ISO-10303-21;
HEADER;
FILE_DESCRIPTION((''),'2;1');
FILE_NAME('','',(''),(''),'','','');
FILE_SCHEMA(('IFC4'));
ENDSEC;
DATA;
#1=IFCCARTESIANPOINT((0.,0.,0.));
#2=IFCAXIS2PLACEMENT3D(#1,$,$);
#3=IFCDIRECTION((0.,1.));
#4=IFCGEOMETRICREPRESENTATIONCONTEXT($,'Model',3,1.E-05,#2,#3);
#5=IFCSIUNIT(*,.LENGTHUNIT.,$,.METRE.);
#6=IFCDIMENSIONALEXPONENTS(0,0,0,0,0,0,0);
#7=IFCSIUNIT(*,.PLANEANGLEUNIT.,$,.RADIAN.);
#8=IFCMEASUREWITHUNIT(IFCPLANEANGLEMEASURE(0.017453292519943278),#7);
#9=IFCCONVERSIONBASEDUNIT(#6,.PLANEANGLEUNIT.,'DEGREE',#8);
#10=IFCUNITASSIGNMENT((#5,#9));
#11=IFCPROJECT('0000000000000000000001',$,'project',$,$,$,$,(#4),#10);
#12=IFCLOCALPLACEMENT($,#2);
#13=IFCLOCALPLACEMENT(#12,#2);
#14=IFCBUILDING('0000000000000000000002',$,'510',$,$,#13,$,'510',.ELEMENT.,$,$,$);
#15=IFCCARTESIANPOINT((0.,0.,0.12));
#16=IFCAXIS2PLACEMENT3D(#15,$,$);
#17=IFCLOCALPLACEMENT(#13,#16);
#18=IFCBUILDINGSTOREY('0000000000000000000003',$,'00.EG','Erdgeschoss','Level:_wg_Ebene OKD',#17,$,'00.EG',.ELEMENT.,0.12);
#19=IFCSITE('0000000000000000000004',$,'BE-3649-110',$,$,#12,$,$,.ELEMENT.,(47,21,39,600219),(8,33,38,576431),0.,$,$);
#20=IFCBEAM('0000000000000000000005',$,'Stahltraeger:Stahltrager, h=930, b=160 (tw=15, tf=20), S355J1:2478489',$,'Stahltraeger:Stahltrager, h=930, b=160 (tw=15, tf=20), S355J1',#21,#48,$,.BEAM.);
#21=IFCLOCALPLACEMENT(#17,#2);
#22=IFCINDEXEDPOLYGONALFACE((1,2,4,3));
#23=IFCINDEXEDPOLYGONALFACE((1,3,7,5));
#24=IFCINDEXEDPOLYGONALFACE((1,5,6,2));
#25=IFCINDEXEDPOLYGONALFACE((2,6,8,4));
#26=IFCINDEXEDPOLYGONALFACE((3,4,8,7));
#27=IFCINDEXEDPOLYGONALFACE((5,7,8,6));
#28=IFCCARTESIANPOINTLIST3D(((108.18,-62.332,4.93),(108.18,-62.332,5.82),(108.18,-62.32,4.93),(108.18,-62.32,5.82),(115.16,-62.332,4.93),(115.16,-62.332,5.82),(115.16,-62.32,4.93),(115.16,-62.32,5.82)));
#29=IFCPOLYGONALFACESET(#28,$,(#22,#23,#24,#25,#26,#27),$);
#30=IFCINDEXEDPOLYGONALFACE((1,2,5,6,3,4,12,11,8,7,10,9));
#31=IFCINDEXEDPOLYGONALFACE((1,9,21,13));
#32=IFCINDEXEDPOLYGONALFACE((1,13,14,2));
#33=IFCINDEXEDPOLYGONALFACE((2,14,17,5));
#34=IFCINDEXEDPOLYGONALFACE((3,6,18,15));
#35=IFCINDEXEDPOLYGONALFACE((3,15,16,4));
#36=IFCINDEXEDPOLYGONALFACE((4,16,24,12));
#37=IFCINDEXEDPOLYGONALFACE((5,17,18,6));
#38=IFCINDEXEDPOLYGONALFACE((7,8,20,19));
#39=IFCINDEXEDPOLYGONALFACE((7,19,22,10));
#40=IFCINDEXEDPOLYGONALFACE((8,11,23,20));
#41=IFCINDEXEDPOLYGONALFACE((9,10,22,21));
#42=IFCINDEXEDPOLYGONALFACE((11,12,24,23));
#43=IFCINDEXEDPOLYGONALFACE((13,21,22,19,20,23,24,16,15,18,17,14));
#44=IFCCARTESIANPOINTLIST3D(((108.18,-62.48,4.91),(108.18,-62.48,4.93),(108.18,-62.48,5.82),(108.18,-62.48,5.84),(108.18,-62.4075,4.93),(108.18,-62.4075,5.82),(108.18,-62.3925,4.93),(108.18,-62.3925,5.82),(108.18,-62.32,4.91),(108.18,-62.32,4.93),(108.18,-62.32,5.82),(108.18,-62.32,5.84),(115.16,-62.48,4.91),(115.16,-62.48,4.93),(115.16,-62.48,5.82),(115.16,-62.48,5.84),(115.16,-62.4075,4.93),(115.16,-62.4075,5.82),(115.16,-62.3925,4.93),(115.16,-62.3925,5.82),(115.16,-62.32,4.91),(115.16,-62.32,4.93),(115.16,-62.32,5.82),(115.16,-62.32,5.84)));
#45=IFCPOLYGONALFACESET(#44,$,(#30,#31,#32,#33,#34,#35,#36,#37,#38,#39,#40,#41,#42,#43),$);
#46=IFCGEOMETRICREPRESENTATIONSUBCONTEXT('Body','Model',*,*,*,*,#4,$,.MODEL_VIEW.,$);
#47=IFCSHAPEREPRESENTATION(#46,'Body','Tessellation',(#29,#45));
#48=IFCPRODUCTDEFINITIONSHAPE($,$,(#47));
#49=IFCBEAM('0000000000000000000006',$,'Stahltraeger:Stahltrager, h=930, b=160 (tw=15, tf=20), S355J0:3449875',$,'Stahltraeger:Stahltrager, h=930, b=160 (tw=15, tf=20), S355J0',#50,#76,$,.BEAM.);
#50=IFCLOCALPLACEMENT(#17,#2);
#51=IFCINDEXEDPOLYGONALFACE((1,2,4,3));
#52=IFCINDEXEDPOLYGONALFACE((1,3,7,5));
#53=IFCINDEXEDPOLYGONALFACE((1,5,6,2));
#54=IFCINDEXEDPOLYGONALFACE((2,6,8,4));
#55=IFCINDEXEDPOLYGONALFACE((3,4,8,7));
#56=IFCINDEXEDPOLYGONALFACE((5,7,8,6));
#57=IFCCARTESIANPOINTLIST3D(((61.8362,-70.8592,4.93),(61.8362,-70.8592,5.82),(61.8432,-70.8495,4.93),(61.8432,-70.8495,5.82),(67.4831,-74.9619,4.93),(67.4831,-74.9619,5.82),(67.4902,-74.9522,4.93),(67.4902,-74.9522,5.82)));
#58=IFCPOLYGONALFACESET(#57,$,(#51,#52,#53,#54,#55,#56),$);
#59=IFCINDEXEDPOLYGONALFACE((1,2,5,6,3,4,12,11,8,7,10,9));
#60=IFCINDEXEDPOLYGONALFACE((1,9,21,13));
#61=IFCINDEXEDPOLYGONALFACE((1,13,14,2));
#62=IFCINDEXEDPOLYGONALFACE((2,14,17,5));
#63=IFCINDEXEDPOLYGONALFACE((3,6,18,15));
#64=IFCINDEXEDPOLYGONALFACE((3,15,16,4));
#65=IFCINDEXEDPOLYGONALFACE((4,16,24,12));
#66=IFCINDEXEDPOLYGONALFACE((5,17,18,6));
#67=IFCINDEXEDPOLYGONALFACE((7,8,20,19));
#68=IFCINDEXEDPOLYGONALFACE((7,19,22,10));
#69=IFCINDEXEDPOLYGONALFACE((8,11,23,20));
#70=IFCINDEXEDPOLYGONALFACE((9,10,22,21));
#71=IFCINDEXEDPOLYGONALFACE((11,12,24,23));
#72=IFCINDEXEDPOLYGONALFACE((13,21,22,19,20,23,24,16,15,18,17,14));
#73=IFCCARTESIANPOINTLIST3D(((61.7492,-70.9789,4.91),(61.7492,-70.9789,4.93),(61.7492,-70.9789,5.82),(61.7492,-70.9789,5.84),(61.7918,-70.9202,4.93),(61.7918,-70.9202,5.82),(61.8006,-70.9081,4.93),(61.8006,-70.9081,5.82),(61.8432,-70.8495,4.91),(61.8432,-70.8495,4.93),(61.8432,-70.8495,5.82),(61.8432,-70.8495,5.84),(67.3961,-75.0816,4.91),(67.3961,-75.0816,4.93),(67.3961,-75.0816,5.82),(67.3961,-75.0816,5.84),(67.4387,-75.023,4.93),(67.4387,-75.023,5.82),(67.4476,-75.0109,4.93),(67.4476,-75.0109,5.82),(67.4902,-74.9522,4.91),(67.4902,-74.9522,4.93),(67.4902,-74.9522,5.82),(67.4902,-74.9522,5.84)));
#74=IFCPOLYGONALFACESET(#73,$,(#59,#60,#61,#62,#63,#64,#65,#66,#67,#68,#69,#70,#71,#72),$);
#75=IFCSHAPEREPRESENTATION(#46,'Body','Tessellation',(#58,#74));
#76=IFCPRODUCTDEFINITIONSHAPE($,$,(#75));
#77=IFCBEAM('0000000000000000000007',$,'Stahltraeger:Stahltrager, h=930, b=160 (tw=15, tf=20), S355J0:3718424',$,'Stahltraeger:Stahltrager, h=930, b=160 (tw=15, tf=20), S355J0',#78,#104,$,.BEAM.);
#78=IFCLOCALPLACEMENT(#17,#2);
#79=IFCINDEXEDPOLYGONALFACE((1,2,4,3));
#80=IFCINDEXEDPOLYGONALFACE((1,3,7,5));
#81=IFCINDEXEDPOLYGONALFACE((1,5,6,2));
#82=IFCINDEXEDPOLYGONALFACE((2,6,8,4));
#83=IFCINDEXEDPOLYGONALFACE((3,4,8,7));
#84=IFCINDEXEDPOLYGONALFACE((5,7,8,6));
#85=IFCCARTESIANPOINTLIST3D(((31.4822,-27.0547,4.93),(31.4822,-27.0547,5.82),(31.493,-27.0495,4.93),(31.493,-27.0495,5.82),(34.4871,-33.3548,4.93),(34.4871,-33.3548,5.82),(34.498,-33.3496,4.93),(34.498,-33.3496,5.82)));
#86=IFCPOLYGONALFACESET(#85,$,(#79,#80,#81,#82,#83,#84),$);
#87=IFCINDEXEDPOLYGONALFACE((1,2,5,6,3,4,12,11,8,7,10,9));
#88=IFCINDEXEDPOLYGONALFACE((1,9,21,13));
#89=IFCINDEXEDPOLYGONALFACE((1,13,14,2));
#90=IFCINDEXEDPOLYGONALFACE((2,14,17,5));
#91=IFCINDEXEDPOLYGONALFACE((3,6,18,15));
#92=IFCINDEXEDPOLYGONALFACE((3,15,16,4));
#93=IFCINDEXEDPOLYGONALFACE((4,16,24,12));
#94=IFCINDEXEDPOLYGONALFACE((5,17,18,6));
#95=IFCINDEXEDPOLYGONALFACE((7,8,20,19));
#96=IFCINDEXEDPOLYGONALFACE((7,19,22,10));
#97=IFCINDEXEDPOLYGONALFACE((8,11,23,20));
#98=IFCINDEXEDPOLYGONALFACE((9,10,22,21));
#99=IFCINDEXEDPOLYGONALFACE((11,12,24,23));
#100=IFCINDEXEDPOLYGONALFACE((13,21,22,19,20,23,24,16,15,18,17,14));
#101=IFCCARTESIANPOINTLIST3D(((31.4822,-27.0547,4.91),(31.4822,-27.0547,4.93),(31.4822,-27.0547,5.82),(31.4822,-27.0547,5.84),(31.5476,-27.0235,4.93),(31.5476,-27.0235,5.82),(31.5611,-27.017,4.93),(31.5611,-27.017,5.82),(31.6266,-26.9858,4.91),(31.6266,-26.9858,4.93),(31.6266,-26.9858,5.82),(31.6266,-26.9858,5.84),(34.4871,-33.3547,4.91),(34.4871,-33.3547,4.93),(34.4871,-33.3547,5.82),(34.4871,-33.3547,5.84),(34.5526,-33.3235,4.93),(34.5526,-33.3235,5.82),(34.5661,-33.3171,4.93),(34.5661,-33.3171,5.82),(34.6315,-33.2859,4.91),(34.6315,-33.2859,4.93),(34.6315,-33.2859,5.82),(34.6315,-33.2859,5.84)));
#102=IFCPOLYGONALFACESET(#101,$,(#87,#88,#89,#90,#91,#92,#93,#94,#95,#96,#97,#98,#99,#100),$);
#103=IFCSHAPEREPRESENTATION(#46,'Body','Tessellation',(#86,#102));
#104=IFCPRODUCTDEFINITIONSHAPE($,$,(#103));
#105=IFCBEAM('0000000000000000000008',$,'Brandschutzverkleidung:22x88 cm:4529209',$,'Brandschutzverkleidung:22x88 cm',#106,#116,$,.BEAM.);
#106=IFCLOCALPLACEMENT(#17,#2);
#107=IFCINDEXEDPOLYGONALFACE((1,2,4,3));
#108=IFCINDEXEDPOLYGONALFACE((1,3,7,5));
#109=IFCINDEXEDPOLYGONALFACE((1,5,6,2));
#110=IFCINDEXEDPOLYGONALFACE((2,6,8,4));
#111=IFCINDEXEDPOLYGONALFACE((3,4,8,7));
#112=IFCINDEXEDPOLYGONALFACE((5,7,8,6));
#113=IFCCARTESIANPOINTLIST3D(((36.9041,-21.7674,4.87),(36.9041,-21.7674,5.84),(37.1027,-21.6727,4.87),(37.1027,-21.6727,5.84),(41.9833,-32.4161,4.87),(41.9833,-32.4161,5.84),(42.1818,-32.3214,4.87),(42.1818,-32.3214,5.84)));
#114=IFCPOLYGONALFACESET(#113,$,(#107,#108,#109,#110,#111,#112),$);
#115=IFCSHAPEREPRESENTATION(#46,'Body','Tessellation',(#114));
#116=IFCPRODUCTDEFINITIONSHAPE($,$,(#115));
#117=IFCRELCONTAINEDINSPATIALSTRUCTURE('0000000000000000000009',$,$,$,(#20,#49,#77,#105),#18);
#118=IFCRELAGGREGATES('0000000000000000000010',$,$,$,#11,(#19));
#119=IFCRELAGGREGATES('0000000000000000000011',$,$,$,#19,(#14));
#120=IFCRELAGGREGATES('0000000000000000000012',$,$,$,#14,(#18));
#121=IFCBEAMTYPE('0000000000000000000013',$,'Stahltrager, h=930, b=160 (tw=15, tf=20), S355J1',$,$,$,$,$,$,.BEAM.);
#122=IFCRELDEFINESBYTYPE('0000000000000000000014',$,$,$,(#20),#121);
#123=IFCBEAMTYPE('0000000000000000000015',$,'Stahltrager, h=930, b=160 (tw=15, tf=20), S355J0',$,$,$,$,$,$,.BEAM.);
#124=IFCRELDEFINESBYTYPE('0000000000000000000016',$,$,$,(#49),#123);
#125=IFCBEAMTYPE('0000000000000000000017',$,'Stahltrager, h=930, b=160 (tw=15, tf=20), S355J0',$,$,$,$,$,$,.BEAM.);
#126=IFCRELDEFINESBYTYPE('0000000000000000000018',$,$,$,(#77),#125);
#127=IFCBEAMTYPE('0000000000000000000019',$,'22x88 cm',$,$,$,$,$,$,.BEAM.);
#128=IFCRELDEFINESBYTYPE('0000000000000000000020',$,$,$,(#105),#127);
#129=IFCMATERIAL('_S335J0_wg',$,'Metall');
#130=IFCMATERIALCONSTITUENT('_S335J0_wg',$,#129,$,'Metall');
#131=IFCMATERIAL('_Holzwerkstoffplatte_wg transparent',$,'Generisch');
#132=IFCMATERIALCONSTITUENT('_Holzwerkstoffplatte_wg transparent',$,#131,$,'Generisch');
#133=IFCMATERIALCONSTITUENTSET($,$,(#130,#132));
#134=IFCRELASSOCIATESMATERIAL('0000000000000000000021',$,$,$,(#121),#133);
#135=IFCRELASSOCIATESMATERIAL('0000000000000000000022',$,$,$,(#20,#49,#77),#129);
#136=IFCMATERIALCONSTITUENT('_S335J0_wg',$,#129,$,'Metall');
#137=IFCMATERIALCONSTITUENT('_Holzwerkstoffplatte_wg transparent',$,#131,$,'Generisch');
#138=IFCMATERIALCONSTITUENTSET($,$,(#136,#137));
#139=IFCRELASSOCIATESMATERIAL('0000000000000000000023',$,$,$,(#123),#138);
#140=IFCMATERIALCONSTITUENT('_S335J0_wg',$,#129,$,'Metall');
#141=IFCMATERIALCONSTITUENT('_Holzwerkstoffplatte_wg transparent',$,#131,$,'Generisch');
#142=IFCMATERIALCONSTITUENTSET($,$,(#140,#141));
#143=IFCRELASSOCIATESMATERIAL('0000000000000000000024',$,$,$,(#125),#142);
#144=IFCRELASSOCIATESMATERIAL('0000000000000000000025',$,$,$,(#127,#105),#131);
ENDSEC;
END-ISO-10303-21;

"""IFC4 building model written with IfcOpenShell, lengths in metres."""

from ifc_helpers import new_model, entity, si_unit, converted_unit, direction, frame, origin, place, context, subcontext, project, spatial, indexed_curve, outline, extrude, source, transform, mapped, material, constituent, constituent_set, type_object, type_shapes, element, save


model = new_model("IFC4")

# Units and contexts
model_context = context("Model", 3, precision=1e-05, world=origin(), true_north=direction((0.0, 1.0)))
body_context = subcontext(model_context, "Body", "Model", "MODEL_VIEW")
ifc_project = project(units=[si_unit("LENGTHUNIT", "METRE"), converted_unit("PLANEANGLEUNIT", "DEGREE", entity("IfcPlaneAngleMeasure", 0.017453292519943278), si_unit("PLANEANGLEUNIT", "RADIAN"), dimensions=[0, 0, 0, 0, 0, 0, 0])], contexts=[model_context])

# Site, building, storey
site_placement = place(None, origin())
site = spatial("IfcSite", under=ifc_project, at=site_placement, Name="BE-3649-110", CompositionType="ELEMENT", RefLatitude=(47, 21, 39, 600219), RefLongitude=(8, 33, 38, 576431), RefElevation=0.0)
building_placement = place(site_placement, origin())
building = spatial("IfcBuilding", under=site, at=building_placement, Name="510", LongName="510", CompositionType="ELEMENT")
storey_placement = place(building_placement, frame((0.0, 0.0, 0.12)))
storey = spatial("IfcBuildingStorey", under=building, at=storey_placement, Name="00.EG", Description="Erdgeschoss", ObjectType="Level:_wg_Ebene OKD", LongName="00.EG", CompositionType="ELEMENT", Elevation=0.12)

# Beams
ifc_material_1 = material(Name="_S335J0_wg", Category="Metall")
ifc_material_2 = material(Name="_Holzwerkstoffplatte_wg transparent", Category="Generisch")
ifc_constituent_1 = constituent(ifc_material_1, Name="_S335J0_wg", Category="Metall")
ifc_constituent_2 = constituent(ifc_material_2, Name="_Holzwerkstoffplatte_wg transparent", Category="Generisch")
ifc_constituent_set_1 = constituent_set(constituents=[ifc_constituent_1, ifc_constituent_2])
beam_type_1 = type_object("IfcBeamType", Name="Stahltrager, h=930, b=160 (tw=15, tf=20), S355J1", PredefinedType="BEAM", material=ifc_constituent_set_1)
shared_shape_1 = source(origin(), body_context, "Body", "SweptSolid", [
    extrude(outline(indexed_curve([(-0.445, -0.006), (0.445, -0.006), (0.445, 0.006), (-0.445, 0.006), (-0.445, -0.006)], self_intersect=False)), frame((108.18, -62.326, 5.495), z_axis=(1.0, 0.0, 0.0), x_axis=(0.0, 0.0, -1.0)), (0.0, 0.0, 1.0), 6.98),
    extrude(outline(indexed_curve([(-0.465, -0.08), (-0.445, -0.08), (-0.445, -0.0075), (0.445, -0.0075), (0.445, -0.08), (0.465, -0.08), (0.465, 0.08), (0.445, 0.08), (0.445, 0.0075), (-0.445, 0.0075), (-0.445, 0.08), (-0.465, 0.08), (-0.465, -0.08)], self_intersect=False)), frame((108.18, -62.4, 5.495), z_axis=(1.0, 0.0, 0.0), x_axis=(0.0, 0.0, -1.0)), (0.0, 0.0, 1.0), 6.98),
])
type_shapes(beam_type_1, [shared_shape_1])
beam_1_placement = place(storey_placement, frame((0.0, 0.0, -0.12)))
element("IfcBeam", 1, at=beam_1_placement, inside=storey, type_object=beam_type_1, material=ifc_material_1, Name="Stahltraeger:Stahltrager, h=930, b=160 (tw=15, tf=20), S355J1:2478489", ObjectType="Stahltraeger:Stahltrager, h=930, b=160 (tw=15, tf=20), S355J1", PredefinedType="BEAM", context=body_context, shape_type="MappedRepresentation", body=[
    mapped(shared_shape_1, transform((0.0, 0.0, 0.0), scale=1.0)),
])
ifc_constituent_3 = constituent(ifc_material_1, Name="_S335J0_wg", Category="Metall")
ifc_constituent_4 = constituent(ifc_material_2, Name="_Holzwerkstoffplatte_wg transparent", Category="Generisch")
ifc_constituent_set_2 = constituent_set(constituents=[ifc_constituent_3, ifc_constituent_4])
beam_type_2 = type_object("IfcBeamType", Name="Stahltrager, h=930, b=160 (tw=15, tf=20), S355J0", PredefinedType="BEAM", material=ifc_constituent_set_2)
shared_shape_2 = source(origin(), body_context, "Body", "SweptSolid", [
    extrude(outline(indexed_curve([(-0.445, -0.006), (0.445, -0.006), (0.445, 0.006), (-0.445, 0.006), (-0.445, -0.006)], self_intersect=False)), frame((61.8397, -70.8543, 5.495), z_axis=(0.809017, -0.587785, 0.0), x_axis=(0.0, 0.0, -1.0)), (0.0, 0.0, 1.0), 6.98),
    extrude(outline(indexed_curve([(-0.465, -0.08), (-0.445, -0.08), (-0.445, -0.0075), (0.445, -0.0075), (0.445, -0.08), (0.465, -0.08), (0.465, 0.08), (0.445, 0.08), (0.445, 0.0075), (-0.445, 0.0075), (-0.445, 0.08), (-0.465, 0.08), (-0.465, -0.08)], self_intersect=False)), frame((61.7962, -70.9142, 5.495), z_axis=(0.809017, -0.587785, 0.0), x_axis=(0.0, 0.0, -1.0)), (0.0, 0.0, 1.0), 6.98),
])
type_shapes(beam_type_2, [shared_shape_2])
beam_2_placement = place(storey_placement, frame((0.0, 0.0, -0.12)))
element("IfcBeam", 2, at=beam_2_placement, inside=storey, type_object=beam_type_2, material=ifc_material_1, Name="Stahltraeger:Stahltrager, h=930, b=160 (tw=15, tf=20), S355J0:3449875", ObjectType="Stahltraeger:Stahltrager, h=930, b=160 (tw=15, tf=20), S355J0", PredefinedType="BEAM", context=body_context, shape_type="MappedRepresentation", body=[
    mapped(shared_shape_2, transform((0.0, 0.0, 0.0), scale=1.0)),
])
ifc_constituent_5 = constituent(ifc_material_1, Name="_S335J0_wg", Category="Metall")
ifc_constituent_6 = constituent(ifc_material_2, Name="_Holzwerkstoffplatte_wg transparent", Category="Generisch")
ifc_constituent_set_3 = constituent_set(constituents=[ifc_constituent_5, ifc_constituent_6])
beam_type_3 = type_object("IfcBeamType", Name="Stahltrager, h=930, b=160 (tw=15, tf=20), S355J0", PredefinedType="BEAM", material=ifc_constituent_set_3)
shared_shape_3 = source(origin(), body_context, "Body", "SweptSolid", [
    extrude(outline(indexed_curve([(-0.445, -0.006), (0.445, -0.006), (0.445, 0.006), (-0.445, 0.006), (-0.445, -0.006)], self_intersect=False)), frame((31.4876, -27.0521, 5.495), z_axis=(0.430511, -0.902585, 0.0), x_axis=(0.0, 0.0, -1.0)), (0.0, 0.0, 1.0), 6.98),
    extrude(outline(indexed_curve([(-0.465, -0.08), (-0.445, -0.08), (-0.445, -0.0075), (0.445, -0.0075), (0.445, -0.08), (0.465, -0.08), (0.465, 0.08), (0.445, 0.08), (0.445, 0.0075), (-0.445, 0.0075), (-0.445, 0.08), (-0.465, 0.08), (-0.465, -0.08)], self_intersect=False)), frame((31.5544, -27.0203, 5.495), z_axis=(0.430511, -0.902585, 0.0), x_axis=(0.0, 0.0, -1.0)), (0.0, 0.0, 1.0), 6.98),
])
type_shapes(beam_type_3, [shared_shape_3])
beam_3_placement = place(storey_placement, frame((0.0, 0.0, -0.12)))
element("IfcBeam", 3, at=beam_3_placement, inside=storey, type_object=beam_type_3, material=ifc_material_1, Name="Stahltraeger:Stahltrager, h=930, b=160 (tw=15, tf=20), S355J0:3718424", ObjectType="Stahltraeger:Stahltrager, h=930, b=160 (tw=15, tf=20), S355J0", PredefinedType="BEAM", context=body_context, shape_type="MappedRepresentation", body=[
    mapped(shared_shape_3, transform((0.0, 0.0, 0.0), scale=1.0)),
])

# Beam
beam_type_4 = type_object("IfcBeamType", Name="22x88 cm", PredefinedType="BEAM", material=ifc_material_2)
shared_shape_4 = source(origin(), body_context, "Body", "SweptSolid", [
    extrude(outline(indexed_curve([(-5.899, -0.11), (5.899, -0.11), (5.899, 0.11), (-5.899, 0.11), (-5.899, -0.11)], self_intersect=False)), frame((39.543, -27.0444, -0.485), z_axis=(0.0, 0.0, 1.0), x_axis=(0.430511, -0.902585, 0.0)), (0.0, 0.0, 1.0), 0.97),
])
type_shapes(beam_type_4, [shared_shape_4])
beam_4_placement = place(storey_placement, frame((0.0, 0.0, 5.355)))
element("IfcBeam", 4, at=beam_4_placement, inside=storey, type_object=beam_type_4, material=ifc_material_2, Name="Brandschutzverkleidung:22x88 cm:4529209", ObjectType="Brandschutzverkleidung:22x88 cm", PredefinedType="BEAM", context=body_context, shape_type="MappedRepresentation", body=[
    mapped(shared_shape_4, transform((0.0, 0.0, 0.0), scale=1.0)),
])

save(model, "model.ifc")
